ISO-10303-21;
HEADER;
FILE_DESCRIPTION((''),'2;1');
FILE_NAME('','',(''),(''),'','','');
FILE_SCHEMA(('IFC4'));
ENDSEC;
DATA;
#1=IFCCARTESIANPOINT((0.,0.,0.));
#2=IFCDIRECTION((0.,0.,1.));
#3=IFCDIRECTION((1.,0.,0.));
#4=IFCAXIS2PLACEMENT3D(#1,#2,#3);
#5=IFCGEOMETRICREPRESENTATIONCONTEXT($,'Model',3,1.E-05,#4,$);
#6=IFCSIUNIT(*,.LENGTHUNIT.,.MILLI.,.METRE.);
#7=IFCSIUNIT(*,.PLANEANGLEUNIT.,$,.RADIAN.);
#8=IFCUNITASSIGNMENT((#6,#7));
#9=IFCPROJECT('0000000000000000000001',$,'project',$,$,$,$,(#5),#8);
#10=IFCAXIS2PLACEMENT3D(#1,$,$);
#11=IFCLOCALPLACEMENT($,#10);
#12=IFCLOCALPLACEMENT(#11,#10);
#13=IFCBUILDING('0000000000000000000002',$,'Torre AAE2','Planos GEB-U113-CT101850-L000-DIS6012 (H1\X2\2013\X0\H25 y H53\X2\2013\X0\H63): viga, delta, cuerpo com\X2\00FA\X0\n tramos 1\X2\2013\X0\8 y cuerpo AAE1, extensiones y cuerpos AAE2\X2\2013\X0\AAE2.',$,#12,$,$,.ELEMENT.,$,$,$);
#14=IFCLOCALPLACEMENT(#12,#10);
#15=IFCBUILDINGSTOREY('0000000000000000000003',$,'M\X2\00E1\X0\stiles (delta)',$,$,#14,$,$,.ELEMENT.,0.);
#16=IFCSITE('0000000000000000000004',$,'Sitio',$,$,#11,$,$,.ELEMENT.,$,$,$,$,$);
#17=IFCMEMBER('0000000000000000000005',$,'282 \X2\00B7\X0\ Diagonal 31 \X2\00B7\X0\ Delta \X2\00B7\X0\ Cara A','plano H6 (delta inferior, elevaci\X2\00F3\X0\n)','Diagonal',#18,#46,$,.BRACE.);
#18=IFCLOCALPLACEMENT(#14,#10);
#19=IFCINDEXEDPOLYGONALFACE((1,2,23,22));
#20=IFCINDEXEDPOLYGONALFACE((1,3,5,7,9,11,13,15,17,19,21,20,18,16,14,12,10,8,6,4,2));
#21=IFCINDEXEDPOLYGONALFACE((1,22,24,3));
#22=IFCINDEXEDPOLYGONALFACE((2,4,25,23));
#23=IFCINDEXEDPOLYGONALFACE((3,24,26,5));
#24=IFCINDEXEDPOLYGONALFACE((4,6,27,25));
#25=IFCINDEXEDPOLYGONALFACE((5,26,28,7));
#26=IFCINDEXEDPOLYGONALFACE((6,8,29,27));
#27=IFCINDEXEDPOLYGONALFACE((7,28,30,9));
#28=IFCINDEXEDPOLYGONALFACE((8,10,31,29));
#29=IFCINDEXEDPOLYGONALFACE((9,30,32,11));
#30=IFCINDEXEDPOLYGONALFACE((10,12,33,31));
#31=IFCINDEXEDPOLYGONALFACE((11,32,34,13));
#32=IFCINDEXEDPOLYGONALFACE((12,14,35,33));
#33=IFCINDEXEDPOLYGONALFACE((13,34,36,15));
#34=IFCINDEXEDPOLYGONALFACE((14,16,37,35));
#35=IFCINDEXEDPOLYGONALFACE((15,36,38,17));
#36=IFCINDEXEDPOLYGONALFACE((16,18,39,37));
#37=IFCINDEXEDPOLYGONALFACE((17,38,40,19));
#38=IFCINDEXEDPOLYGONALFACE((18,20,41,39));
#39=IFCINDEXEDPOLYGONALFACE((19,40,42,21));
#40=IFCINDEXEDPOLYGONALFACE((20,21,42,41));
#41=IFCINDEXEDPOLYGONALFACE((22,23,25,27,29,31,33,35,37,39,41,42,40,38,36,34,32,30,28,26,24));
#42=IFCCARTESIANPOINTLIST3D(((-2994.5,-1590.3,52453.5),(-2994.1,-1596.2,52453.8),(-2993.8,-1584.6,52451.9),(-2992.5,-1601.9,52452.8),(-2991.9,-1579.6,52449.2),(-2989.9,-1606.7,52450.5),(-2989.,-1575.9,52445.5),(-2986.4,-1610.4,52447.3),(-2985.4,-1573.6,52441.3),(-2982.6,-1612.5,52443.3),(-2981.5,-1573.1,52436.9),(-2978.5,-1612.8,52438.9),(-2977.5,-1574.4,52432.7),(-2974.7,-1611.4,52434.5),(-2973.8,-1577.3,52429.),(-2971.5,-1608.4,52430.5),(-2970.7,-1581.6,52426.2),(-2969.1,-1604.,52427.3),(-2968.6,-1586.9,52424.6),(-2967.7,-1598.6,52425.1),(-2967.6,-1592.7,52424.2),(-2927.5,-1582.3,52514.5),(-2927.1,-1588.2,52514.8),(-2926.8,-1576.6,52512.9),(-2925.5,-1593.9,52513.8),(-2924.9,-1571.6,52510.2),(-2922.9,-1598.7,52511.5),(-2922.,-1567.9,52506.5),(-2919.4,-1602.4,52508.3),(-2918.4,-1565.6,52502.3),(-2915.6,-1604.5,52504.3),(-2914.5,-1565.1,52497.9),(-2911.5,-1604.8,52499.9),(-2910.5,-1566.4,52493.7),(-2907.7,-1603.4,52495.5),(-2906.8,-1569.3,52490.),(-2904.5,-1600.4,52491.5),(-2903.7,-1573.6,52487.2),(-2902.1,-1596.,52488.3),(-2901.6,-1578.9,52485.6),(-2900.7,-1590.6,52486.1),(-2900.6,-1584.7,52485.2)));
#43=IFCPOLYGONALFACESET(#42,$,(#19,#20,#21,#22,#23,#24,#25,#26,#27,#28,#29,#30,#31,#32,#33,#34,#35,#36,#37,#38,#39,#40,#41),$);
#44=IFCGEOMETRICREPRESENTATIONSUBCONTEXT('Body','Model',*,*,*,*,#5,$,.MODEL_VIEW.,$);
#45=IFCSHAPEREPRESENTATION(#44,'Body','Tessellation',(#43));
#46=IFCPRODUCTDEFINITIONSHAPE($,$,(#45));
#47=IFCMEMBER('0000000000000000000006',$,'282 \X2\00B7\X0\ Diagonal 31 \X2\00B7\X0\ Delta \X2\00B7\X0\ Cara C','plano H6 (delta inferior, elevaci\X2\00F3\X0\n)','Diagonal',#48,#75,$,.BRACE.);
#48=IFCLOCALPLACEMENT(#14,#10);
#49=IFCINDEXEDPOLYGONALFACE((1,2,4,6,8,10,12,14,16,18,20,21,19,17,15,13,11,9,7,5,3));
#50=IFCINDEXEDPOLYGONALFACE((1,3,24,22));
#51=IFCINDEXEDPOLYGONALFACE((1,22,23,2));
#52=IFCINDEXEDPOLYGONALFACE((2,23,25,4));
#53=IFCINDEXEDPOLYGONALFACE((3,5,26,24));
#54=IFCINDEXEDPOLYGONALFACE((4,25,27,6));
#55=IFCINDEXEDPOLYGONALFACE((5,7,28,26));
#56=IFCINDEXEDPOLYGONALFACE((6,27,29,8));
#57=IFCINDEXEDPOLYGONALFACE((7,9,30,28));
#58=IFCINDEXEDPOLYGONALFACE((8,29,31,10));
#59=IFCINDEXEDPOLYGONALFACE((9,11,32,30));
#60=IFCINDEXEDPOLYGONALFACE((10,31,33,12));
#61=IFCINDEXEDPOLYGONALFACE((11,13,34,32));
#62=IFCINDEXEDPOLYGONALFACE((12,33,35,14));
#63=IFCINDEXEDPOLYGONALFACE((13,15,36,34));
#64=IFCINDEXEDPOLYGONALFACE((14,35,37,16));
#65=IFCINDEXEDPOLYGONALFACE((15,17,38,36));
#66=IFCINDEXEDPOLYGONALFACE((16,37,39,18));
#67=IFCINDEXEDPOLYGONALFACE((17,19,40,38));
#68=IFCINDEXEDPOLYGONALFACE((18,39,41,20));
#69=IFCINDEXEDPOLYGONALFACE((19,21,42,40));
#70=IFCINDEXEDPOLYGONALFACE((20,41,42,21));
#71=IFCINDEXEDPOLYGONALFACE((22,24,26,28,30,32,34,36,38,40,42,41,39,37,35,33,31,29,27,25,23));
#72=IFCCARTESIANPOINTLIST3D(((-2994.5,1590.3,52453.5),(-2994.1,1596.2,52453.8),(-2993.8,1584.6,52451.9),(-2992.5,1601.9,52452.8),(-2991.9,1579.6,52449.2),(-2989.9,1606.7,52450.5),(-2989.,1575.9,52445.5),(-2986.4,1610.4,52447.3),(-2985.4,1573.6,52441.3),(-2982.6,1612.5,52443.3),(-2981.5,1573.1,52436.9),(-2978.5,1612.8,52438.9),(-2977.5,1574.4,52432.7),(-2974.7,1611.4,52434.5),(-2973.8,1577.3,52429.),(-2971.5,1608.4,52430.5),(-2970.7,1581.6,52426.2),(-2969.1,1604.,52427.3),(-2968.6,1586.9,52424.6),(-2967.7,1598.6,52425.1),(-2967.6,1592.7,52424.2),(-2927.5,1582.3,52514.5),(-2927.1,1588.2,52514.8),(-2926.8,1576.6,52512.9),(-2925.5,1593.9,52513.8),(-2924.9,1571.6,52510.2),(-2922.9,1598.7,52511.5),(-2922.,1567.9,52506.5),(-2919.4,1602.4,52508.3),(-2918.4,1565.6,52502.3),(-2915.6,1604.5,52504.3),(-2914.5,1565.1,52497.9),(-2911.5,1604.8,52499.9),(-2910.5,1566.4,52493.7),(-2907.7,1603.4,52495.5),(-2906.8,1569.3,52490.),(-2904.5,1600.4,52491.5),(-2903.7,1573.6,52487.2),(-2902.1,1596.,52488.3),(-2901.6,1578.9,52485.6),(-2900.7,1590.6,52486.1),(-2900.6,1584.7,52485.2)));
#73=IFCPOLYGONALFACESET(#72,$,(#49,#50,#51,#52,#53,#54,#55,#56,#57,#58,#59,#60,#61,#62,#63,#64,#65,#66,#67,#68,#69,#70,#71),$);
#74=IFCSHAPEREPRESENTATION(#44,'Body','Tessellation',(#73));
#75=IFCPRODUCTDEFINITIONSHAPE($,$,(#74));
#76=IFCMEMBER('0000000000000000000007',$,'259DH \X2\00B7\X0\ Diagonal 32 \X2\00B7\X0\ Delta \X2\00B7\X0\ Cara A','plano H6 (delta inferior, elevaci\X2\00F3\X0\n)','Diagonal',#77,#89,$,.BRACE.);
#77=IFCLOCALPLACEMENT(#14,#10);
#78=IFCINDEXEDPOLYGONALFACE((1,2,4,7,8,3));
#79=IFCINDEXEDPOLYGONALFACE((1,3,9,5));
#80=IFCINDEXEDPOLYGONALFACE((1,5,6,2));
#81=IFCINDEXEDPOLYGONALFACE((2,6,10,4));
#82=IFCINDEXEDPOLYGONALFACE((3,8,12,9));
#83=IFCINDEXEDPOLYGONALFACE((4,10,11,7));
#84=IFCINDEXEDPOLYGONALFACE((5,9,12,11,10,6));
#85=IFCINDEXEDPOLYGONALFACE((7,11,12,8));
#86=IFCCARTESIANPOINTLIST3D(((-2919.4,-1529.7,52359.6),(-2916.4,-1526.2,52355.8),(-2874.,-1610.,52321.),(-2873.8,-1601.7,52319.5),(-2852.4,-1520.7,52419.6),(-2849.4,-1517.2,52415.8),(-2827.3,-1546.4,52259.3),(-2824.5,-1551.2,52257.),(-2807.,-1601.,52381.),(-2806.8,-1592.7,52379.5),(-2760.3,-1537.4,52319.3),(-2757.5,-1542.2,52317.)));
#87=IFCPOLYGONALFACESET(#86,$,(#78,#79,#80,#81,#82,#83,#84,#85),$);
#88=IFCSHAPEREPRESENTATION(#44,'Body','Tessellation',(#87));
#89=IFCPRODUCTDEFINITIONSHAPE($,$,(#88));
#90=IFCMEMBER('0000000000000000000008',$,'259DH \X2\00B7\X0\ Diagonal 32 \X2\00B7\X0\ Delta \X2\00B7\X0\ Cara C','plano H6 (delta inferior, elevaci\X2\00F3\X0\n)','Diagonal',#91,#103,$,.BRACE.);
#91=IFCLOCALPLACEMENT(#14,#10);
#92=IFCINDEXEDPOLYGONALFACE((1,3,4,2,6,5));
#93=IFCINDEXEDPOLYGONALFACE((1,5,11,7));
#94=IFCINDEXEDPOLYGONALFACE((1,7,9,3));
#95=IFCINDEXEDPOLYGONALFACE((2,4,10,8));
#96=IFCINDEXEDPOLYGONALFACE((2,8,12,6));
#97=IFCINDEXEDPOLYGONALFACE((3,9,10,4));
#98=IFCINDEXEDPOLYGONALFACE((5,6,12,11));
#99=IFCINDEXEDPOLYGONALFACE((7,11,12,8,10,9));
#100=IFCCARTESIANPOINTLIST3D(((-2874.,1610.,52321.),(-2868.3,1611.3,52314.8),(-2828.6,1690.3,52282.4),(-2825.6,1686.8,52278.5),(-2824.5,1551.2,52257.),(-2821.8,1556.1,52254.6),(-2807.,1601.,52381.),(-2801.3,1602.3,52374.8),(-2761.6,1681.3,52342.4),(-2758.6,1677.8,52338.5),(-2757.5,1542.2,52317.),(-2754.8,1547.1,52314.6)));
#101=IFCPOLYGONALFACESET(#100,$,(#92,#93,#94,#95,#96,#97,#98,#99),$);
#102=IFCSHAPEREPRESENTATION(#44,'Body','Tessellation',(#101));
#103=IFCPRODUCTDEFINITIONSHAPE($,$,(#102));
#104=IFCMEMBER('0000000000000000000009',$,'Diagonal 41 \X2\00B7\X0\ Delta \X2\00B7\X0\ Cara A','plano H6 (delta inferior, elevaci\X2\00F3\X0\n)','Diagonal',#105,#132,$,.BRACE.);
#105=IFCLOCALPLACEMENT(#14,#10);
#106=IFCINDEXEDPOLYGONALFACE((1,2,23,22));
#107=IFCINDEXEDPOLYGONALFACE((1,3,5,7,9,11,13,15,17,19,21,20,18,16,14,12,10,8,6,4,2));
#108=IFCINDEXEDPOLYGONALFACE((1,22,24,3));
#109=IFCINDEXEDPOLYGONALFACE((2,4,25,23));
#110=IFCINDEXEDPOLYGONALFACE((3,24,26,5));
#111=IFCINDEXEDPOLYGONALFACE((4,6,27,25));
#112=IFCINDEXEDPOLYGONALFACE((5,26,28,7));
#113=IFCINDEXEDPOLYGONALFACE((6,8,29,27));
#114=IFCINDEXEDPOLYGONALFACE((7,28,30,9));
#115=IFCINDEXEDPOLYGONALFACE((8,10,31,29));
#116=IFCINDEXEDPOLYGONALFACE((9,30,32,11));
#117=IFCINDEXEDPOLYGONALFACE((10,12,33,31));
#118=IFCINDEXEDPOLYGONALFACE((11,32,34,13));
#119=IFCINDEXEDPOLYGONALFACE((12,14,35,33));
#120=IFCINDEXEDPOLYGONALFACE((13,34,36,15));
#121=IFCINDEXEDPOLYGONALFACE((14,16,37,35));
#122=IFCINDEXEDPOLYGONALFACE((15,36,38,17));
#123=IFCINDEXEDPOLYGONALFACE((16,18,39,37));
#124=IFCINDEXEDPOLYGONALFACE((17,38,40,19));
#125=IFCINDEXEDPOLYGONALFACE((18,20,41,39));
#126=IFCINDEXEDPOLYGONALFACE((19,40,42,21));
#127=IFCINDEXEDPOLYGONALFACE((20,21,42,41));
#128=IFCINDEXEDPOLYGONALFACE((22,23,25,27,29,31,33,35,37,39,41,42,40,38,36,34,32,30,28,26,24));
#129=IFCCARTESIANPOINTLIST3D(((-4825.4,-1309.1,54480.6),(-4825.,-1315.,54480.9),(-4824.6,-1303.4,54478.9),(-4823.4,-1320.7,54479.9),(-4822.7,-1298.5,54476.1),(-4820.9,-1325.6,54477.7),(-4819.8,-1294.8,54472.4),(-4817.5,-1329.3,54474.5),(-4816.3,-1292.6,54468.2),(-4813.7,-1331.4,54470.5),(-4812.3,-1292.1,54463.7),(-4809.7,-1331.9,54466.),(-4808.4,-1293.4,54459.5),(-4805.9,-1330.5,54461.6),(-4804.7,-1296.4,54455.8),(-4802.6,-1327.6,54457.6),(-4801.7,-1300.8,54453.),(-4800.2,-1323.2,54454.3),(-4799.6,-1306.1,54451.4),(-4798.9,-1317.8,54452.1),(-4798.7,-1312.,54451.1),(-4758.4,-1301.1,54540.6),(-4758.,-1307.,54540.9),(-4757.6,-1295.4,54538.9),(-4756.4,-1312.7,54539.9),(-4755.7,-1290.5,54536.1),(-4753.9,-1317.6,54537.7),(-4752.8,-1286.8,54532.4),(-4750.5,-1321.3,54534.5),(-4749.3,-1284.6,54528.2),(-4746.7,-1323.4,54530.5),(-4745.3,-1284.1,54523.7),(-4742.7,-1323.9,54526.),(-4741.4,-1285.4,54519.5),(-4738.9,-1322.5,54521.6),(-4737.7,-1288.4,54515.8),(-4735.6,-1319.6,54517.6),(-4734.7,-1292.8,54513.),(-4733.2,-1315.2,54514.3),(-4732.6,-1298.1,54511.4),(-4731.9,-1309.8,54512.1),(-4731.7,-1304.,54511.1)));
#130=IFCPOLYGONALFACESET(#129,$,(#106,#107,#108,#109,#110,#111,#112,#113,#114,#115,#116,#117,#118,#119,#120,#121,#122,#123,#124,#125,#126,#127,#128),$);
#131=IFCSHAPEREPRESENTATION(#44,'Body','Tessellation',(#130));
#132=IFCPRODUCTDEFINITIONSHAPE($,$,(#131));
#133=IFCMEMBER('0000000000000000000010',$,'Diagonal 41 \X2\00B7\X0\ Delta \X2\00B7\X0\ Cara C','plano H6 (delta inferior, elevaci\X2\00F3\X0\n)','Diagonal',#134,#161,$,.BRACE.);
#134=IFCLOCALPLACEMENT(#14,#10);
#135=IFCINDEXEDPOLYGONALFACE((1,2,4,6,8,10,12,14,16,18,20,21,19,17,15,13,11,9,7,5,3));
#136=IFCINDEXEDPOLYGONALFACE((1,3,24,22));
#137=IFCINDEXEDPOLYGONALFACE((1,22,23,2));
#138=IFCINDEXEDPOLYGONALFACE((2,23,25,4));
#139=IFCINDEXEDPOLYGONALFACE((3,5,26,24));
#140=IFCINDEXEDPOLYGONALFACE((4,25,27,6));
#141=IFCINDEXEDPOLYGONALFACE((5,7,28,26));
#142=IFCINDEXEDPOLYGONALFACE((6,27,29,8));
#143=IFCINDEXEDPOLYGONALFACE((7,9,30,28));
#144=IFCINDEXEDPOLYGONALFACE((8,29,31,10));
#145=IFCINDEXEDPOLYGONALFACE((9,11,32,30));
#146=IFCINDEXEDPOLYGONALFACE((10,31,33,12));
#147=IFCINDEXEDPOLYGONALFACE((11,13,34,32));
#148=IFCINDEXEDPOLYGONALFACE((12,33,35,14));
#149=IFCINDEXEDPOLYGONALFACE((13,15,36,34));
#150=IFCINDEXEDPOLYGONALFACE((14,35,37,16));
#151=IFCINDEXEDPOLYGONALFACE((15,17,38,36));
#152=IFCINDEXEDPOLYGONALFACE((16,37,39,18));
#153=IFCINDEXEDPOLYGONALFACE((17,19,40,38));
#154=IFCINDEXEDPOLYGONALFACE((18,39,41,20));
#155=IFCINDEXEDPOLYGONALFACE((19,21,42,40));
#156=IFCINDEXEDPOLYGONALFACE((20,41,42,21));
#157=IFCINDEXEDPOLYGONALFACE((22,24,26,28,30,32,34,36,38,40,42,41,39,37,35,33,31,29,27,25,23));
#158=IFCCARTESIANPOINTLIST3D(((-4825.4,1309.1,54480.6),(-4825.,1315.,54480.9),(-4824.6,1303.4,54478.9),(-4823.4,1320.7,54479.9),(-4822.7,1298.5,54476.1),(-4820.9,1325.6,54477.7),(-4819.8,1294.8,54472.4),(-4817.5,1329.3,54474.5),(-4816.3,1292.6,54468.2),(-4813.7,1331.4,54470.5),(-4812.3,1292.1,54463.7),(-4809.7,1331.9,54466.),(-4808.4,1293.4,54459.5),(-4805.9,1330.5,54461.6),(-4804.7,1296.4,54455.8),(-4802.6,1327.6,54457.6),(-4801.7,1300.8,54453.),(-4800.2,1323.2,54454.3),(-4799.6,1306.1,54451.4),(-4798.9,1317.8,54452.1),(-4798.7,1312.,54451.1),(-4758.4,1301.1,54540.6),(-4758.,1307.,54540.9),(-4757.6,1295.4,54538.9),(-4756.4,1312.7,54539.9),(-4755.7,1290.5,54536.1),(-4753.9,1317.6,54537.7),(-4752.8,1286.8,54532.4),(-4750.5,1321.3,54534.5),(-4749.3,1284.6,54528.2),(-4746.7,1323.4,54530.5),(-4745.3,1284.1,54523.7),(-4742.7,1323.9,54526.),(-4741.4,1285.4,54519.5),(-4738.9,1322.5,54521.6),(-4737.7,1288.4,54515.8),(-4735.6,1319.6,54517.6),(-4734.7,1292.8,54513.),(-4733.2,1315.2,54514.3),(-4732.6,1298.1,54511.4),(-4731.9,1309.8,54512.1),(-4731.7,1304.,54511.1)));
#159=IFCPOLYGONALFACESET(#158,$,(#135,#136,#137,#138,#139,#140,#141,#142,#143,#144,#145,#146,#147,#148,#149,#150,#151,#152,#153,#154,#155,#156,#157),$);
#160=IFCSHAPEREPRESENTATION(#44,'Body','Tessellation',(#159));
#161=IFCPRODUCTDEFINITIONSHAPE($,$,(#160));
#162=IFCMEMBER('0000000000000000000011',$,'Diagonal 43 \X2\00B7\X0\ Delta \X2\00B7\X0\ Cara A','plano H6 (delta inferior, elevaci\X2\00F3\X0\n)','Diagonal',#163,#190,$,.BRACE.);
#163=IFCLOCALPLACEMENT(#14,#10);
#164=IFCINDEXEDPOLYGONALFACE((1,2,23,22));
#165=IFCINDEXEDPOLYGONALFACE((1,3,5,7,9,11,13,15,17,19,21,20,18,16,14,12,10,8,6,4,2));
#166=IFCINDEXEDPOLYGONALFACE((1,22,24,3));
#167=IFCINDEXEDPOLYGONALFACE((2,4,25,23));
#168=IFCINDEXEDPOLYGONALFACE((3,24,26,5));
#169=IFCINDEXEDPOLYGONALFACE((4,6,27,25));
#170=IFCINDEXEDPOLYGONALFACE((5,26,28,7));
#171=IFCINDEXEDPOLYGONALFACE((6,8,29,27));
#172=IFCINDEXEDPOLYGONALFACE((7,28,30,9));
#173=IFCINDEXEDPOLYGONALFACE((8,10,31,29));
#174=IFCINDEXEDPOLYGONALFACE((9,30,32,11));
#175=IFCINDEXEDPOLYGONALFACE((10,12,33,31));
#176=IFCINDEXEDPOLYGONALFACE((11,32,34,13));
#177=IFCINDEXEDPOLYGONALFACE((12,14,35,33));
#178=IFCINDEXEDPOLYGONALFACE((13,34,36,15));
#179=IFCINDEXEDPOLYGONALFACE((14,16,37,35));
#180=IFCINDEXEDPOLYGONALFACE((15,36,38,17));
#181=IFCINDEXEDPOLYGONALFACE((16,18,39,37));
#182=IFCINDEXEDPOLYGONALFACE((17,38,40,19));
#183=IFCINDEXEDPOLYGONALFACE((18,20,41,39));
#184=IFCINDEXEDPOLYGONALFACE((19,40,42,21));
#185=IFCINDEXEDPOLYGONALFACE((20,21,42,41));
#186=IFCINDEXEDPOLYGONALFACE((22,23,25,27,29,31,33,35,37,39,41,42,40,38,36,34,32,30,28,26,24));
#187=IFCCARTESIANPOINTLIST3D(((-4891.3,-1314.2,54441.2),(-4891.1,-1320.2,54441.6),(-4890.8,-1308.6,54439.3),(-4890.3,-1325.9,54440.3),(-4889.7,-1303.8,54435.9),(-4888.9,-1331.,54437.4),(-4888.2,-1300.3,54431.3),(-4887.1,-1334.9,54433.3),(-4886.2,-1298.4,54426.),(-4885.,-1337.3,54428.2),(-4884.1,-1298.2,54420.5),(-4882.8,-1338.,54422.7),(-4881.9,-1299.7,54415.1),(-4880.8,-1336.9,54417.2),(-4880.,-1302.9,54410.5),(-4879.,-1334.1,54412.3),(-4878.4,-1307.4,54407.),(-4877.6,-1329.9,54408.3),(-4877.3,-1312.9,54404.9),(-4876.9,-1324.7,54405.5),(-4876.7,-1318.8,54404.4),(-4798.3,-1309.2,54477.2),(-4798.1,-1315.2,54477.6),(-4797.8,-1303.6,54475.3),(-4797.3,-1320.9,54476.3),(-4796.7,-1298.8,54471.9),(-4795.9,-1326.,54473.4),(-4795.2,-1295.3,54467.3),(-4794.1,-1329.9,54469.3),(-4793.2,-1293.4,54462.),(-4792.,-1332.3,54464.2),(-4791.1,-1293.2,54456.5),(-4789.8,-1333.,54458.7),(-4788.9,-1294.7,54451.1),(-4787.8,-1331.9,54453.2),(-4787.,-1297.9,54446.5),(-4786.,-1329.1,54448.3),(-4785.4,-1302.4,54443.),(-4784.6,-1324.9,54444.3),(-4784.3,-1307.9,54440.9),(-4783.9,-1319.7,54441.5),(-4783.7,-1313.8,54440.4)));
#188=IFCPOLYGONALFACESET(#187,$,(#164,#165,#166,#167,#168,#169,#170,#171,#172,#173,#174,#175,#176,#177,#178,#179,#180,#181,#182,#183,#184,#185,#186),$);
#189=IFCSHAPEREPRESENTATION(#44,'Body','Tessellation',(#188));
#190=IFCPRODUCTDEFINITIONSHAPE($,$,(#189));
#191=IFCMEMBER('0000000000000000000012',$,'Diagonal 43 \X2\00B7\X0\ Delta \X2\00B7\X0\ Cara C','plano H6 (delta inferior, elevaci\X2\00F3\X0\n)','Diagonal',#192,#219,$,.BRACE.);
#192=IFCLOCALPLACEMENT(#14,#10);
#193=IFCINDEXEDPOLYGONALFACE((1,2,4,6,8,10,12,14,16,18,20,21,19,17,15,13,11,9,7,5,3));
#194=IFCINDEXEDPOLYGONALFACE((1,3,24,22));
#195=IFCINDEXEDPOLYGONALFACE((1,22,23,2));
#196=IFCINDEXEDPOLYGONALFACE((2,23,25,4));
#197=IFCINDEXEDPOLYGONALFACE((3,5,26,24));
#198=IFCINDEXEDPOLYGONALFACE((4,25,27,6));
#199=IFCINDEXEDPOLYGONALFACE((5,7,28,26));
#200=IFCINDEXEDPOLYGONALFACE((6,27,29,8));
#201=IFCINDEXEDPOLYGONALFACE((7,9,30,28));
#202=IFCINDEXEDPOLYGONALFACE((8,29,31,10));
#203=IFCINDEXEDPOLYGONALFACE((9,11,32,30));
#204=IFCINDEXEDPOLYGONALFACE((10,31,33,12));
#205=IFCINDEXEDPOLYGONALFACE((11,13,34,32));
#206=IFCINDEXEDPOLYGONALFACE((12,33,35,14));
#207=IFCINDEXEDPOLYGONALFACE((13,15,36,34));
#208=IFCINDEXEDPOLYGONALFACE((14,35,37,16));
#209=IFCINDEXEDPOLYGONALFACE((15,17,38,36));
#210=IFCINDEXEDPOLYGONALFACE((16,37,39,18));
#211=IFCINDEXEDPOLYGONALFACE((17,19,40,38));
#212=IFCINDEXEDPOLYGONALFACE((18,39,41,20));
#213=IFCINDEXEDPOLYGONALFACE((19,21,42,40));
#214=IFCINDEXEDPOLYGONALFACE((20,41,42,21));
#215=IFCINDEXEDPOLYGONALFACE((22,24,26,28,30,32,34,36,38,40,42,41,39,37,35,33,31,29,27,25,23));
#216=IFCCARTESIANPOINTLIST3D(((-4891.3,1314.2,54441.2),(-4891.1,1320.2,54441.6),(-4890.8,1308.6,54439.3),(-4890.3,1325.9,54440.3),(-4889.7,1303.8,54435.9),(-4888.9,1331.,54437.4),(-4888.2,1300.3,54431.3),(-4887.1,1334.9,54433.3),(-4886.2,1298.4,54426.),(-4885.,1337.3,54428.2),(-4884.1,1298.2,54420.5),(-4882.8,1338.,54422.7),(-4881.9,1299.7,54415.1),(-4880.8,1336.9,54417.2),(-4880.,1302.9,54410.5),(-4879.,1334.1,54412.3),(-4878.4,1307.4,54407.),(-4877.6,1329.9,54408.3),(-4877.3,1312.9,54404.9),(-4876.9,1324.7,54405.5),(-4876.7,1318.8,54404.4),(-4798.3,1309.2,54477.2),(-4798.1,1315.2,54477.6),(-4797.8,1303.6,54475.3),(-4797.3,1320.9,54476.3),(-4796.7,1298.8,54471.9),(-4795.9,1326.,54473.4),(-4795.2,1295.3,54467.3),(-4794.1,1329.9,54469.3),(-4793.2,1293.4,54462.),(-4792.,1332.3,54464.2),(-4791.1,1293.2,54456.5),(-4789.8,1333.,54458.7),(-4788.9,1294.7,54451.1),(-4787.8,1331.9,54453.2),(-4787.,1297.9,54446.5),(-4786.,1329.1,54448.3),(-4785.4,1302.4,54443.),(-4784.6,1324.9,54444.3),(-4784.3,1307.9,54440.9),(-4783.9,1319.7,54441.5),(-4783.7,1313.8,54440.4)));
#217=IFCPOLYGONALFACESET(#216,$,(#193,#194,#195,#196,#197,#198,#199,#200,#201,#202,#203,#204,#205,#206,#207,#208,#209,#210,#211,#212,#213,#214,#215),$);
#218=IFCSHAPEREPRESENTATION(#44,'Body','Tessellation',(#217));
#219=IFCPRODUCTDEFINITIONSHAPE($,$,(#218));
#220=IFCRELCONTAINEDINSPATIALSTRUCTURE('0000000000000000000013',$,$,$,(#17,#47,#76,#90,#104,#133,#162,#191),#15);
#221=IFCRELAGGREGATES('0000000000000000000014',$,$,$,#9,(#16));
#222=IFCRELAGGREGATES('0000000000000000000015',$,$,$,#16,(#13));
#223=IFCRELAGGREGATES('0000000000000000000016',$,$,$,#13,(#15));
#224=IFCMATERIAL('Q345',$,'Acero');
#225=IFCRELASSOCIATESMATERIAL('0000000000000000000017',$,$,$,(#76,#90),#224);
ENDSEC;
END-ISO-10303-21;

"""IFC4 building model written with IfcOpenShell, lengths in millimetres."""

from ifc_helpers import new_model, si_unit, frame, frame_2d, origin, origin_with_axes, place, context, subcontext, project, spatial, circle, l_section, extrude, material, element, save


model = new_model("IFC4")

# Units and contexts
model_context = context("Model", 3, precision=1e-05, world=origin_with_axes())
body_context = subcontext(model_context, "Body", "Model", "MODEL_VIEW")
ifc_project = project(units=[si_unit("LENGTHUNIT", "METRE", prefix="MILLI"), si_unit("PLANEANGLEUNIT", "RADIAN")], contexts=[model_context])

# Site, building, storey
site_placement = place(None, origin())
site = spatial("IfcSite", under=ifc_project, at=site_placement, Name="Sitio", CompositionType="ELEMENT")
building_placement = place(site_placement, origin())
building = spatial("IfcBuilding", under=site, at=building_placement, Name="Torre AAE2", Description="Planos GEB-U113-CT101850-L000-DIS6012 (H1–H25 y H53–H63): viga, delta, cuerpo común tramos 1–8 y cuerpo AAE1, extensiones y cuerpos AAE2–AAE2.", CompositionType="ELEMENT")
storey_placement = place(building_placement, origin())
storey = spatial("IfcBuildingStorey", under=building, at=storey_placement, Name="Mástiles (delta)", CompositionType="ELEMENT", Elevation=0.0)

# Members
ifc_material_1 = material(Name="Q345", Category="Acero")
for number, where, z_axis, x_axis, name in (
    (1, (-2981.0, -1593.0, 52439.0), (0.736575, 0.087949, 0.670613), (0.513914, 0.571828, -0.639457), "282 · Diagonal 31 · Delta · Cara A"),
    (2, (-2981.0, 1593.0, 52439.0), (0.736575, -0.087949, 0.670613), (0.513914, -0.571828, -0.639457), "282 · Diagonal 31 · Delta · Cara C"),
):
    element("IfcMember", number, at=place(storey_placement, frame(where, z_axis=z_axis, x_axis=x_axis)), inside=storey, Name=name, Description="plano H6 (delta inferior, elevación)", ObjectType="Diagonal", PredefinedType="BRACE", context=body_context, shape_type="SweptSolid", body=[
        extrude(circle(Radius=20.0), None, (0.0, 0.0, 1.0), 91.0),
    ])
for number, where, z_axis, x_axis, name in (
    (3, (-2874.0, -1610.0, 52321.0), (0.741248, 0.099571, 0.663805), (0.494542, 0.587651, -0.640386), "259DH · Diagonal 32 · Delta · Cara A"),
    (4, (-2874.0, 1610.0, 52321.0), (0.741248, -0.099571, 0.663805), (0.494542, -0.587651, -0.640386), "259DH · Diagonal 32 · Delta · Cara C"),
):
    element("IfcMember", number, at=place(storey_placement, frame(where, z_axis=z_axis, x_axis=x_axis)), inside=storey, material=ifc_material_1, Name=name, Description="plano H6 (delta inferior, elevación)", ObjectType="Diagonal", PredefinedType="BRACE", context=body_context, shape_type="SweptSolid", body=[
        extrude(l_section(Depth=100.0, Width=100.0, Thickness=6.0, at=frame_2d((50.0, 50.0))), None, (0.0, 0.0, 1.0), 90.4),
    ])
for number, where, z_axis, x_axis, name in (
    (5, (-4812.0, -1312.0, 54466.0), (0.742021, 0.088599, 0.664496), (0.617718, 0.294726, -0.729082), "Diagonal 41 · Delta · Cara A"),
    (6, (-4812.0, 1312.0, 54466.0), (0.742021, -0.088599, 0.664496), (0.617718, -0.294726, -0.729082), "Diagonal 41 · Delta · Cara C"),
):
    element("IfcMember", number, at=place(storey_placement, frame(where, z_axis=z_axis, x_axis=x_axis)), inside=storey, Name=name, Description="plano H6 (delta inferior, elevación)", ObjectType="Diagonal", PredefinedType="BRACE", context=body_context, shape_type="SweptSolid", body=[
        extrude(circle(Radius=20.0), None, (0.0, 0.0, 1.0), 90.3),
    ])
for number, where, z_axis, x_axis, name in (
    (7, (-4791.0, -1313.0, 54459.0), (-0.931398, -0.050075, -0.360541), (0.281705, 0.528113, -0.801086), "Diagonal 43 · Delta · Cara A"),
    (8, (-4791.0, 1313.0, 54459.0), (-0.931398, 0.050075, -0.360541), (0.281705, -0.528113, -0.801086), "Diagonal 43 · Delta · Cara C"),
):
    element("IfcMember", number, at=place(storey_placement, frame(where, z_axis=z_axis, x_axis=x_axis)), inside=storey, Name=name, Description="plano H6 (delta inferior, elevación)", ObjectType="Diagonal", PredefinedType="BRACE", context=body_context, shape_type="SweptSolid", body=[
        extrude(circle(Radius=20.0), None, (0.0, 0.0, 1.0), 99.8),
    ])

save(model, "model.ifc")
